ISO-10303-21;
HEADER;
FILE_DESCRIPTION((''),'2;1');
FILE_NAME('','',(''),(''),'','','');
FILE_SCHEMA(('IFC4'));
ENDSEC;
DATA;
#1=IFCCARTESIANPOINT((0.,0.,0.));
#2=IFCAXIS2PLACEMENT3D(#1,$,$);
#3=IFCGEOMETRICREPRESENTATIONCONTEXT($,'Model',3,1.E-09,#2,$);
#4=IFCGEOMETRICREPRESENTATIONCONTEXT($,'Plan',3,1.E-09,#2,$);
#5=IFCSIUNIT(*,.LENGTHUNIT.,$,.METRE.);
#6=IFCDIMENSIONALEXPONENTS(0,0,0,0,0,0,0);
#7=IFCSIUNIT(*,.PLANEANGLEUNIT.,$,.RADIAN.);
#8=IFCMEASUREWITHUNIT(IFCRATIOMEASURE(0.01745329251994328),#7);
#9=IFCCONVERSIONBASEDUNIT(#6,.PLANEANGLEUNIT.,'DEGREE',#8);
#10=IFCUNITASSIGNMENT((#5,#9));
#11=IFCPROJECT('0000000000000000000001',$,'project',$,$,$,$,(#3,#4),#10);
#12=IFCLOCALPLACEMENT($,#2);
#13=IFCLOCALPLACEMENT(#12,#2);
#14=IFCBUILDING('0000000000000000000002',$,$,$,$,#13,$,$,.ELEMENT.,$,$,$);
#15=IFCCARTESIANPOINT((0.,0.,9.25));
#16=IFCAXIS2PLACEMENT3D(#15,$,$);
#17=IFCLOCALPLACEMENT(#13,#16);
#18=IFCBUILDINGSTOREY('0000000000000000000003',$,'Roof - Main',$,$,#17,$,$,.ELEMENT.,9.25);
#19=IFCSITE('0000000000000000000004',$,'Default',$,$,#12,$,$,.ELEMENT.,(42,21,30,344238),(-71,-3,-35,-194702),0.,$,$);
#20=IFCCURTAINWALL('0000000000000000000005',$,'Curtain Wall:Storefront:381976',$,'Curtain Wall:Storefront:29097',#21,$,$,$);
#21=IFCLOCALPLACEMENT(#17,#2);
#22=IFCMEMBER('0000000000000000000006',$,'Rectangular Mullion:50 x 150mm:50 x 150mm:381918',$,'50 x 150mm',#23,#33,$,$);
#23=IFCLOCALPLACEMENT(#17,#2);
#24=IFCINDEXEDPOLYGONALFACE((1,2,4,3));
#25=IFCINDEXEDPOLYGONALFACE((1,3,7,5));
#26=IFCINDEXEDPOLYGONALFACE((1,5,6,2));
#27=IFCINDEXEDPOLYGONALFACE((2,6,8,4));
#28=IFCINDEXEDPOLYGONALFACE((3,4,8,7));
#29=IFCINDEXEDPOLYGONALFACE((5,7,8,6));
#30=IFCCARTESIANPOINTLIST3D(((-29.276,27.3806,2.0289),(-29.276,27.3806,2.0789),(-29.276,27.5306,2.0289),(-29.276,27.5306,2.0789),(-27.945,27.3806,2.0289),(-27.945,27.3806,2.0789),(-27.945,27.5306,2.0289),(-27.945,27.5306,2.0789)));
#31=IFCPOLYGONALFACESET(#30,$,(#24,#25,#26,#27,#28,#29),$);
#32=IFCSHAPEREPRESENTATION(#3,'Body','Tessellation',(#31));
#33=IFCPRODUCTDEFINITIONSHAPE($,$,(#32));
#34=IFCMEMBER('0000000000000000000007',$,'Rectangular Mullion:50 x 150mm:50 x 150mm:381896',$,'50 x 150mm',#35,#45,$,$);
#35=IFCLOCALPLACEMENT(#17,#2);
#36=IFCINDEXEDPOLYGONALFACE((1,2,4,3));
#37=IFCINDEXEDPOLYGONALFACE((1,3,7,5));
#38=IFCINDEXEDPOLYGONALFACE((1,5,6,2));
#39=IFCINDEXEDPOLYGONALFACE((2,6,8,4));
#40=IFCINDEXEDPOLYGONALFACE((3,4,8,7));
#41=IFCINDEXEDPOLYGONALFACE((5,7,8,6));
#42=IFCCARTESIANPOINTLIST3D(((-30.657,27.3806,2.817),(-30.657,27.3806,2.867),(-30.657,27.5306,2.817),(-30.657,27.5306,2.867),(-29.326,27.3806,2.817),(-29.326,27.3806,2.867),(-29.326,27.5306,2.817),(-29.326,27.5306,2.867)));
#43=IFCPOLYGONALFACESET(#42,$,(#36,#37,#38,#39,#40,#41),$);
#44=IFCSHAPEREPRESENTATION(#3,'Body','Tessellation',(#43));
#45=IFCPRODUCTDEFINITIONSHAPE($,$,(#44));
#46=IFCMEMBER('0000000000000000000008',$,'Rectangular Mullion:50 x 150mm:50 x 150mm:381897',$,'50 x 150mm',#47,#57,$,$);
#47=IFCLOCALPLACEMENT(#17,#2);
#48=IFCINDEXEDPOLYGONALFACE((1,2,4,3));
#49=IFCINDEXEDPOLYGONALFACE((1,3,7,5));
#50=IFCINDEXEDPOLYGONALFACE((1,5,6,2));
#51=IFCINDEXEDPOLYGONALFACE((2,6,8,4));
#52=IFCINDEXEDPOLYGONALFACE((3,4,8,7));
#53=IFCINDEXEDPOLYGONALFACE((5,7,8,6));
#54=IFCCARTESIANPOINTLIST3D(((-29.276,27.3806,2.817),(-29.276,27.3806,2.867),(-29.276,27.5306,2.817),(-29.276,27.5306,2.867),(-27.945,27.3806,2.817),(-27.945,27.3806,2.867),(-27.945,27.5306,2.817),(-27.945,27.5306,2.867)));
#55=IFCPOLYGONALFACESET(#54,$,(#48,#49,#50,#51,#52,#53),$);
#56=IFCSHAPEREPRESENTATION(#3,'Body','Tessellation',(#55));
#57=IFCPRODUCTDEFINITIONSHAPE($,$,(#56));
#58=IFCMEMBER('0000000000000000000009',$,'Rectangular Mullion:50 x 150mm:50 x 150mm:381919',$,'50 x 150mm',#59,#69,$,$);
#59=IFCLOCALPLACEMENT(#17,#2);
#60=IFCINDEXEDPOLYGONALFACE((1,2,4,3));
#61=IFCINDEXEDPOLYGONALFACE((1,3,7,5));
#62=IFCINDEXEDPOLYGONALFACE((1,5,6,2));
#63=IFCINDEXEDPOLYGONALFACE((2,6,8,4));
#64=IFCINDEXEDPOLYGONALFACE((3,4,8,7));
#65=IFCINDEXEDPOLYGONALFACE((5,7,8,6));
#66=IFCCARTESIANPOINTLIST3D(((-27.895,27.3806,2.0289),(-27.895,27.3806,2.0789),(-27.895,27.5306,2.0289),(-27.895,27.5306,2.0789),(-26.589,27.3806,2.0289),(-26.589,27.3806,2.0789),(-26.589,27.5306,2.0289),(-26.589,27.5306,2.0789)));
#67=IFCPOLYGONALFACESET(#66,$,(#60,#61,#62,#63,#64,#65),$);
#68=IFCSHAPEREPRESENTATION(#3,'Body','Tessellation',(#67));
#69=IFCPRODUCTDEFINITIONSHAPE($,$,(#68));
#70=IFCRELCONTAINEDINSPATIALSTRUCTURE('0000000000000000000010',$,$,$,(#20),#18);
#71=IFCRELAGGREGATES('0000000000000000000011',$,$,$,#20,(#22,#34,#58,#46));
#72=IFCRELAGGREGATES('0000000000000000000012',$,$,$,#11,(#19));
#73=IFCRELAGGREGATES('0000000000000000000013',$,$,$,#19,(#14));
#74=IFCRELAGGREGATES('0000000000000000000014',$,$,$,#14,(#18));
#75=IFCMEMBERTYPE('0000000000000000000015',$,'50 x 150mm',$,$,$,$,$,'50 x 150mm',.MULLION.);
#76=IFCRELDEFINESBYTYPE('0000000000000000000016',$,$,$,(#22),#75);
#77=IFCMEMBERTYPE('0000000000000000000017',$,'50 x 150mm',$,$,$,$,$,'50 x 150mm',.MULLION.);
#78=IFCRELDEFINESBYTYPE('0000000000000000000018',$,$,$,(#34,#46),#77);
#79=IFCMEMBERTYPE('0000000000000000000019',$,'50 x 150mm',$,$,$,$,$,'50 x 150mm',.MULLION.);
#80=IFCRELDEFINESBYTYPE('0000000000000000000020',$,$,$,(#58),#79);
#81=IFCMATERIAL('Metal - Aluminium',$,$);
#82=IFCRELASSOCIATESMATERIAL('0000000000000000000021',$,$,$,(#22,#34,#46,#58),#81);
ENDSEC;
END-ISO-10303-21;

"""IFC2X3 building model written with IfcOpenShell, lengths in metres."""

from ifc_helpers import new_model, entity, si_unit, converted_unit, frame, origin, origin_2d_with_axis, place, context, project, spatial, rectangle, extrude, source, transform, mapped, material, type_object, type_shapes, element, aggregate, save


model = new_model("IFC2X3")

# Units and contexts
model_context = context("Model", 3, precision=1e-09, world=origin())
plan_context = context("Plan", 3, precision=1e-09, world=origin())
ifc_project = project(units=[si_unit("LENGTHUNIT", "METRE"), converted_unit("PLANEANGLEUNIT", "DEGREE", entity("IfcRatioMeasure", 0.01745329251994328), si_unit("PLANEANGLEUNIT", "RADIAN"), dimensions=[0, 0, 0, 0, 0, 0, 0])], contexts=[model_context, plan_context])

# Site, building, storey
site_placement = place(None, origin())
site = spatial("IfcSite", under=ifc_project, at=site_placement, Name="Default", CompositionType="ELEMENT", RefLatitude=(42, 21, 30, 344238), RefLongitude=(-71, -3, -35, -194702), RefElevation=0.0)
building_placement = place(site_placement, origin())
building = spatial("IfcBuilding", under=site, at=building_placement, CompositionType="ELEMENT")
storey_placement = place(building_placement, frame((0.0, 0.0, 9.25)))
storey = spatial("IfcBuildingStorey", under=building, at=storey_placement, Name="Roof - Main", CompositionType="ELEMENT", Elevation=9.25)

# Curtain wall
curtain_wall_1_placement = place(storey_placement, origin())
curtain_wall_1 = element("IfcCurtainWall", 1, at=curtain_wall_1_placement, inside=storey, Name="Curtain Wall:Storefront:381976", ObjectType="Curtain Wall:Storefront:29097")
ifc_material_1 = material(Name="Metal - Aluminium")

# Members
member_type_1 = type_object("IfcMemberType", Name="50 x 150mm", ElementType="50 x 150mm", PredefinedType="MULLION")
shared_shape_1 = source(origin(), model_context, "Body", "SweptSolid", [
    extrude(rectangle(XDim=0.05, YDim=0.15, at=origin_2d_with_axis()), frame((0.0, 0.0, -1.331), z_axis=(0.0, 0.0, 1.0), x_axis=(-1.0, 0.0, 0.0)), (0.0, 0.0, 1.0), 1.331),
])
type_shapes(member_type_1, [shared_shape_1])
member_1_placement = place(storey_placement, frame((-27.945, 27.4556, 2.0539), z_axis=(1.0, 0.0, 0.0), x_axis=(0.0, 0.0, 1.0)))
member_1 = element("IfcMember", 2, at=member_1_placement, type_object=member_type_1, material=ifc_material_1, Name="Rectangular Mullion:50 x 150mm:50 x 150mm:381918", ObjectType="50 x 150mm", context=model_context, shape_type="MappedRepresentation", body=[
    mapped(shared_shape_1, transform((0.0, 0.0, 0.0), scale=1.0)),
])
member_type_2 = type_object("IfcMemberType", Name="50 x 150mm", ElementType="50 x 150mm", PredefinedType="MULLION")
shared_shape_2 = source(origin(), model_context, "Body", "SweptSolid", [
    extrude(rectangle(XDim=0.05, YDim=0.15, at=origin_2d_with_axis()), frame((-0.025, 0.0, -1.331), z_axis=(0.0, 0.0, 1.0), x_axis=(-1.0, 0.0, 0.0)), (0.0, 0.0, 1.0), 1.331),
])
type_shapes(member_type_2, [shared_shape_2])
member_2_placement = place(storey_placement, frame((-29.326, 27.4556, 2.867), z_axis=(1.0, 0.0, 0.0), x_axis=(0.0, 0.0, 1.0)))
member_2 = element("IfcMember", 3, at=member_2_placement, type_object=member_type_2, material=ifc_material_1, Name="Rectangular Mullion:50 x 150mm:50 x 150mm:381896", ObjectType="50 x 150mm", context=model_context, shape_type="MappedRepresentation", body=[
    mapped(shared_shape_2, transform((0.0, 0.0, 0.0), scale=1.0)),
])
member_3_placement = place(storey_placement, frame((-27.945, 27.4556, 2.867), z_axis=(1.0, 0.0, 0.0), x_axis=(0.0, 0.0, 1.0)))
member_3 = element("IfcMember", 4, at=member_3_placement, type_object=member_type_2, material=ifc_material_1, Name="Rectangular Mullion:50 x 150mm:50 x 150mm:381897", ObjectType="50 x 150mm", context=model_context, shape_type="MappedRepresentation", body=[
    mapped(shared_shape_2, transform((0.0, 0.0, 0.0), scale=1.0)),
])
member_type_3 = type_object("IfcMemberType", Name="50 x 150mm", ElementType="50 x 150mm", PredefinedType="MULLION")
shared_shape_3 = source(origin(), model_context, "Body", "SweptSolid", [
    extrude(rectangle(XDim=0.05, YDim=0.15, at=origin_2d_with_axis()), frame((0.0, 0.0, -1.306), z_axis=(0.0, 0.0, 1.0), x_axis=(-1.0, 0.0, 0.0)), (0.0, 0.0, 1.0), 1.306),
])
type_shapes(member_type_3, [shared_shape_3])
member_4_placement = place(storey_placement, frame((-26.589, 27.4556, 2.0539), z_axis=(1.0, 0.0, 0.0), x_axis=(0.0, 0.0, 1.0)))
member_4 = element("IfcMember", 5, at=member_4_placement, type_object=member_type_3, material=ifc_material_1, Name="Rectangular Mullion:50 x 150mm:50 x 150mm:381919", ObjectType="50 x 150mm", context=model_context, shape_type="MappedRepresentation", body=[
    mapped(shared_shape_3, transform((0.0, 0.0, 0.0), scale=1.0)),
])

aggregate(curtain_wall_1, [member_1, member_2, member_4, member_3])

save(model, "model.ifc")
